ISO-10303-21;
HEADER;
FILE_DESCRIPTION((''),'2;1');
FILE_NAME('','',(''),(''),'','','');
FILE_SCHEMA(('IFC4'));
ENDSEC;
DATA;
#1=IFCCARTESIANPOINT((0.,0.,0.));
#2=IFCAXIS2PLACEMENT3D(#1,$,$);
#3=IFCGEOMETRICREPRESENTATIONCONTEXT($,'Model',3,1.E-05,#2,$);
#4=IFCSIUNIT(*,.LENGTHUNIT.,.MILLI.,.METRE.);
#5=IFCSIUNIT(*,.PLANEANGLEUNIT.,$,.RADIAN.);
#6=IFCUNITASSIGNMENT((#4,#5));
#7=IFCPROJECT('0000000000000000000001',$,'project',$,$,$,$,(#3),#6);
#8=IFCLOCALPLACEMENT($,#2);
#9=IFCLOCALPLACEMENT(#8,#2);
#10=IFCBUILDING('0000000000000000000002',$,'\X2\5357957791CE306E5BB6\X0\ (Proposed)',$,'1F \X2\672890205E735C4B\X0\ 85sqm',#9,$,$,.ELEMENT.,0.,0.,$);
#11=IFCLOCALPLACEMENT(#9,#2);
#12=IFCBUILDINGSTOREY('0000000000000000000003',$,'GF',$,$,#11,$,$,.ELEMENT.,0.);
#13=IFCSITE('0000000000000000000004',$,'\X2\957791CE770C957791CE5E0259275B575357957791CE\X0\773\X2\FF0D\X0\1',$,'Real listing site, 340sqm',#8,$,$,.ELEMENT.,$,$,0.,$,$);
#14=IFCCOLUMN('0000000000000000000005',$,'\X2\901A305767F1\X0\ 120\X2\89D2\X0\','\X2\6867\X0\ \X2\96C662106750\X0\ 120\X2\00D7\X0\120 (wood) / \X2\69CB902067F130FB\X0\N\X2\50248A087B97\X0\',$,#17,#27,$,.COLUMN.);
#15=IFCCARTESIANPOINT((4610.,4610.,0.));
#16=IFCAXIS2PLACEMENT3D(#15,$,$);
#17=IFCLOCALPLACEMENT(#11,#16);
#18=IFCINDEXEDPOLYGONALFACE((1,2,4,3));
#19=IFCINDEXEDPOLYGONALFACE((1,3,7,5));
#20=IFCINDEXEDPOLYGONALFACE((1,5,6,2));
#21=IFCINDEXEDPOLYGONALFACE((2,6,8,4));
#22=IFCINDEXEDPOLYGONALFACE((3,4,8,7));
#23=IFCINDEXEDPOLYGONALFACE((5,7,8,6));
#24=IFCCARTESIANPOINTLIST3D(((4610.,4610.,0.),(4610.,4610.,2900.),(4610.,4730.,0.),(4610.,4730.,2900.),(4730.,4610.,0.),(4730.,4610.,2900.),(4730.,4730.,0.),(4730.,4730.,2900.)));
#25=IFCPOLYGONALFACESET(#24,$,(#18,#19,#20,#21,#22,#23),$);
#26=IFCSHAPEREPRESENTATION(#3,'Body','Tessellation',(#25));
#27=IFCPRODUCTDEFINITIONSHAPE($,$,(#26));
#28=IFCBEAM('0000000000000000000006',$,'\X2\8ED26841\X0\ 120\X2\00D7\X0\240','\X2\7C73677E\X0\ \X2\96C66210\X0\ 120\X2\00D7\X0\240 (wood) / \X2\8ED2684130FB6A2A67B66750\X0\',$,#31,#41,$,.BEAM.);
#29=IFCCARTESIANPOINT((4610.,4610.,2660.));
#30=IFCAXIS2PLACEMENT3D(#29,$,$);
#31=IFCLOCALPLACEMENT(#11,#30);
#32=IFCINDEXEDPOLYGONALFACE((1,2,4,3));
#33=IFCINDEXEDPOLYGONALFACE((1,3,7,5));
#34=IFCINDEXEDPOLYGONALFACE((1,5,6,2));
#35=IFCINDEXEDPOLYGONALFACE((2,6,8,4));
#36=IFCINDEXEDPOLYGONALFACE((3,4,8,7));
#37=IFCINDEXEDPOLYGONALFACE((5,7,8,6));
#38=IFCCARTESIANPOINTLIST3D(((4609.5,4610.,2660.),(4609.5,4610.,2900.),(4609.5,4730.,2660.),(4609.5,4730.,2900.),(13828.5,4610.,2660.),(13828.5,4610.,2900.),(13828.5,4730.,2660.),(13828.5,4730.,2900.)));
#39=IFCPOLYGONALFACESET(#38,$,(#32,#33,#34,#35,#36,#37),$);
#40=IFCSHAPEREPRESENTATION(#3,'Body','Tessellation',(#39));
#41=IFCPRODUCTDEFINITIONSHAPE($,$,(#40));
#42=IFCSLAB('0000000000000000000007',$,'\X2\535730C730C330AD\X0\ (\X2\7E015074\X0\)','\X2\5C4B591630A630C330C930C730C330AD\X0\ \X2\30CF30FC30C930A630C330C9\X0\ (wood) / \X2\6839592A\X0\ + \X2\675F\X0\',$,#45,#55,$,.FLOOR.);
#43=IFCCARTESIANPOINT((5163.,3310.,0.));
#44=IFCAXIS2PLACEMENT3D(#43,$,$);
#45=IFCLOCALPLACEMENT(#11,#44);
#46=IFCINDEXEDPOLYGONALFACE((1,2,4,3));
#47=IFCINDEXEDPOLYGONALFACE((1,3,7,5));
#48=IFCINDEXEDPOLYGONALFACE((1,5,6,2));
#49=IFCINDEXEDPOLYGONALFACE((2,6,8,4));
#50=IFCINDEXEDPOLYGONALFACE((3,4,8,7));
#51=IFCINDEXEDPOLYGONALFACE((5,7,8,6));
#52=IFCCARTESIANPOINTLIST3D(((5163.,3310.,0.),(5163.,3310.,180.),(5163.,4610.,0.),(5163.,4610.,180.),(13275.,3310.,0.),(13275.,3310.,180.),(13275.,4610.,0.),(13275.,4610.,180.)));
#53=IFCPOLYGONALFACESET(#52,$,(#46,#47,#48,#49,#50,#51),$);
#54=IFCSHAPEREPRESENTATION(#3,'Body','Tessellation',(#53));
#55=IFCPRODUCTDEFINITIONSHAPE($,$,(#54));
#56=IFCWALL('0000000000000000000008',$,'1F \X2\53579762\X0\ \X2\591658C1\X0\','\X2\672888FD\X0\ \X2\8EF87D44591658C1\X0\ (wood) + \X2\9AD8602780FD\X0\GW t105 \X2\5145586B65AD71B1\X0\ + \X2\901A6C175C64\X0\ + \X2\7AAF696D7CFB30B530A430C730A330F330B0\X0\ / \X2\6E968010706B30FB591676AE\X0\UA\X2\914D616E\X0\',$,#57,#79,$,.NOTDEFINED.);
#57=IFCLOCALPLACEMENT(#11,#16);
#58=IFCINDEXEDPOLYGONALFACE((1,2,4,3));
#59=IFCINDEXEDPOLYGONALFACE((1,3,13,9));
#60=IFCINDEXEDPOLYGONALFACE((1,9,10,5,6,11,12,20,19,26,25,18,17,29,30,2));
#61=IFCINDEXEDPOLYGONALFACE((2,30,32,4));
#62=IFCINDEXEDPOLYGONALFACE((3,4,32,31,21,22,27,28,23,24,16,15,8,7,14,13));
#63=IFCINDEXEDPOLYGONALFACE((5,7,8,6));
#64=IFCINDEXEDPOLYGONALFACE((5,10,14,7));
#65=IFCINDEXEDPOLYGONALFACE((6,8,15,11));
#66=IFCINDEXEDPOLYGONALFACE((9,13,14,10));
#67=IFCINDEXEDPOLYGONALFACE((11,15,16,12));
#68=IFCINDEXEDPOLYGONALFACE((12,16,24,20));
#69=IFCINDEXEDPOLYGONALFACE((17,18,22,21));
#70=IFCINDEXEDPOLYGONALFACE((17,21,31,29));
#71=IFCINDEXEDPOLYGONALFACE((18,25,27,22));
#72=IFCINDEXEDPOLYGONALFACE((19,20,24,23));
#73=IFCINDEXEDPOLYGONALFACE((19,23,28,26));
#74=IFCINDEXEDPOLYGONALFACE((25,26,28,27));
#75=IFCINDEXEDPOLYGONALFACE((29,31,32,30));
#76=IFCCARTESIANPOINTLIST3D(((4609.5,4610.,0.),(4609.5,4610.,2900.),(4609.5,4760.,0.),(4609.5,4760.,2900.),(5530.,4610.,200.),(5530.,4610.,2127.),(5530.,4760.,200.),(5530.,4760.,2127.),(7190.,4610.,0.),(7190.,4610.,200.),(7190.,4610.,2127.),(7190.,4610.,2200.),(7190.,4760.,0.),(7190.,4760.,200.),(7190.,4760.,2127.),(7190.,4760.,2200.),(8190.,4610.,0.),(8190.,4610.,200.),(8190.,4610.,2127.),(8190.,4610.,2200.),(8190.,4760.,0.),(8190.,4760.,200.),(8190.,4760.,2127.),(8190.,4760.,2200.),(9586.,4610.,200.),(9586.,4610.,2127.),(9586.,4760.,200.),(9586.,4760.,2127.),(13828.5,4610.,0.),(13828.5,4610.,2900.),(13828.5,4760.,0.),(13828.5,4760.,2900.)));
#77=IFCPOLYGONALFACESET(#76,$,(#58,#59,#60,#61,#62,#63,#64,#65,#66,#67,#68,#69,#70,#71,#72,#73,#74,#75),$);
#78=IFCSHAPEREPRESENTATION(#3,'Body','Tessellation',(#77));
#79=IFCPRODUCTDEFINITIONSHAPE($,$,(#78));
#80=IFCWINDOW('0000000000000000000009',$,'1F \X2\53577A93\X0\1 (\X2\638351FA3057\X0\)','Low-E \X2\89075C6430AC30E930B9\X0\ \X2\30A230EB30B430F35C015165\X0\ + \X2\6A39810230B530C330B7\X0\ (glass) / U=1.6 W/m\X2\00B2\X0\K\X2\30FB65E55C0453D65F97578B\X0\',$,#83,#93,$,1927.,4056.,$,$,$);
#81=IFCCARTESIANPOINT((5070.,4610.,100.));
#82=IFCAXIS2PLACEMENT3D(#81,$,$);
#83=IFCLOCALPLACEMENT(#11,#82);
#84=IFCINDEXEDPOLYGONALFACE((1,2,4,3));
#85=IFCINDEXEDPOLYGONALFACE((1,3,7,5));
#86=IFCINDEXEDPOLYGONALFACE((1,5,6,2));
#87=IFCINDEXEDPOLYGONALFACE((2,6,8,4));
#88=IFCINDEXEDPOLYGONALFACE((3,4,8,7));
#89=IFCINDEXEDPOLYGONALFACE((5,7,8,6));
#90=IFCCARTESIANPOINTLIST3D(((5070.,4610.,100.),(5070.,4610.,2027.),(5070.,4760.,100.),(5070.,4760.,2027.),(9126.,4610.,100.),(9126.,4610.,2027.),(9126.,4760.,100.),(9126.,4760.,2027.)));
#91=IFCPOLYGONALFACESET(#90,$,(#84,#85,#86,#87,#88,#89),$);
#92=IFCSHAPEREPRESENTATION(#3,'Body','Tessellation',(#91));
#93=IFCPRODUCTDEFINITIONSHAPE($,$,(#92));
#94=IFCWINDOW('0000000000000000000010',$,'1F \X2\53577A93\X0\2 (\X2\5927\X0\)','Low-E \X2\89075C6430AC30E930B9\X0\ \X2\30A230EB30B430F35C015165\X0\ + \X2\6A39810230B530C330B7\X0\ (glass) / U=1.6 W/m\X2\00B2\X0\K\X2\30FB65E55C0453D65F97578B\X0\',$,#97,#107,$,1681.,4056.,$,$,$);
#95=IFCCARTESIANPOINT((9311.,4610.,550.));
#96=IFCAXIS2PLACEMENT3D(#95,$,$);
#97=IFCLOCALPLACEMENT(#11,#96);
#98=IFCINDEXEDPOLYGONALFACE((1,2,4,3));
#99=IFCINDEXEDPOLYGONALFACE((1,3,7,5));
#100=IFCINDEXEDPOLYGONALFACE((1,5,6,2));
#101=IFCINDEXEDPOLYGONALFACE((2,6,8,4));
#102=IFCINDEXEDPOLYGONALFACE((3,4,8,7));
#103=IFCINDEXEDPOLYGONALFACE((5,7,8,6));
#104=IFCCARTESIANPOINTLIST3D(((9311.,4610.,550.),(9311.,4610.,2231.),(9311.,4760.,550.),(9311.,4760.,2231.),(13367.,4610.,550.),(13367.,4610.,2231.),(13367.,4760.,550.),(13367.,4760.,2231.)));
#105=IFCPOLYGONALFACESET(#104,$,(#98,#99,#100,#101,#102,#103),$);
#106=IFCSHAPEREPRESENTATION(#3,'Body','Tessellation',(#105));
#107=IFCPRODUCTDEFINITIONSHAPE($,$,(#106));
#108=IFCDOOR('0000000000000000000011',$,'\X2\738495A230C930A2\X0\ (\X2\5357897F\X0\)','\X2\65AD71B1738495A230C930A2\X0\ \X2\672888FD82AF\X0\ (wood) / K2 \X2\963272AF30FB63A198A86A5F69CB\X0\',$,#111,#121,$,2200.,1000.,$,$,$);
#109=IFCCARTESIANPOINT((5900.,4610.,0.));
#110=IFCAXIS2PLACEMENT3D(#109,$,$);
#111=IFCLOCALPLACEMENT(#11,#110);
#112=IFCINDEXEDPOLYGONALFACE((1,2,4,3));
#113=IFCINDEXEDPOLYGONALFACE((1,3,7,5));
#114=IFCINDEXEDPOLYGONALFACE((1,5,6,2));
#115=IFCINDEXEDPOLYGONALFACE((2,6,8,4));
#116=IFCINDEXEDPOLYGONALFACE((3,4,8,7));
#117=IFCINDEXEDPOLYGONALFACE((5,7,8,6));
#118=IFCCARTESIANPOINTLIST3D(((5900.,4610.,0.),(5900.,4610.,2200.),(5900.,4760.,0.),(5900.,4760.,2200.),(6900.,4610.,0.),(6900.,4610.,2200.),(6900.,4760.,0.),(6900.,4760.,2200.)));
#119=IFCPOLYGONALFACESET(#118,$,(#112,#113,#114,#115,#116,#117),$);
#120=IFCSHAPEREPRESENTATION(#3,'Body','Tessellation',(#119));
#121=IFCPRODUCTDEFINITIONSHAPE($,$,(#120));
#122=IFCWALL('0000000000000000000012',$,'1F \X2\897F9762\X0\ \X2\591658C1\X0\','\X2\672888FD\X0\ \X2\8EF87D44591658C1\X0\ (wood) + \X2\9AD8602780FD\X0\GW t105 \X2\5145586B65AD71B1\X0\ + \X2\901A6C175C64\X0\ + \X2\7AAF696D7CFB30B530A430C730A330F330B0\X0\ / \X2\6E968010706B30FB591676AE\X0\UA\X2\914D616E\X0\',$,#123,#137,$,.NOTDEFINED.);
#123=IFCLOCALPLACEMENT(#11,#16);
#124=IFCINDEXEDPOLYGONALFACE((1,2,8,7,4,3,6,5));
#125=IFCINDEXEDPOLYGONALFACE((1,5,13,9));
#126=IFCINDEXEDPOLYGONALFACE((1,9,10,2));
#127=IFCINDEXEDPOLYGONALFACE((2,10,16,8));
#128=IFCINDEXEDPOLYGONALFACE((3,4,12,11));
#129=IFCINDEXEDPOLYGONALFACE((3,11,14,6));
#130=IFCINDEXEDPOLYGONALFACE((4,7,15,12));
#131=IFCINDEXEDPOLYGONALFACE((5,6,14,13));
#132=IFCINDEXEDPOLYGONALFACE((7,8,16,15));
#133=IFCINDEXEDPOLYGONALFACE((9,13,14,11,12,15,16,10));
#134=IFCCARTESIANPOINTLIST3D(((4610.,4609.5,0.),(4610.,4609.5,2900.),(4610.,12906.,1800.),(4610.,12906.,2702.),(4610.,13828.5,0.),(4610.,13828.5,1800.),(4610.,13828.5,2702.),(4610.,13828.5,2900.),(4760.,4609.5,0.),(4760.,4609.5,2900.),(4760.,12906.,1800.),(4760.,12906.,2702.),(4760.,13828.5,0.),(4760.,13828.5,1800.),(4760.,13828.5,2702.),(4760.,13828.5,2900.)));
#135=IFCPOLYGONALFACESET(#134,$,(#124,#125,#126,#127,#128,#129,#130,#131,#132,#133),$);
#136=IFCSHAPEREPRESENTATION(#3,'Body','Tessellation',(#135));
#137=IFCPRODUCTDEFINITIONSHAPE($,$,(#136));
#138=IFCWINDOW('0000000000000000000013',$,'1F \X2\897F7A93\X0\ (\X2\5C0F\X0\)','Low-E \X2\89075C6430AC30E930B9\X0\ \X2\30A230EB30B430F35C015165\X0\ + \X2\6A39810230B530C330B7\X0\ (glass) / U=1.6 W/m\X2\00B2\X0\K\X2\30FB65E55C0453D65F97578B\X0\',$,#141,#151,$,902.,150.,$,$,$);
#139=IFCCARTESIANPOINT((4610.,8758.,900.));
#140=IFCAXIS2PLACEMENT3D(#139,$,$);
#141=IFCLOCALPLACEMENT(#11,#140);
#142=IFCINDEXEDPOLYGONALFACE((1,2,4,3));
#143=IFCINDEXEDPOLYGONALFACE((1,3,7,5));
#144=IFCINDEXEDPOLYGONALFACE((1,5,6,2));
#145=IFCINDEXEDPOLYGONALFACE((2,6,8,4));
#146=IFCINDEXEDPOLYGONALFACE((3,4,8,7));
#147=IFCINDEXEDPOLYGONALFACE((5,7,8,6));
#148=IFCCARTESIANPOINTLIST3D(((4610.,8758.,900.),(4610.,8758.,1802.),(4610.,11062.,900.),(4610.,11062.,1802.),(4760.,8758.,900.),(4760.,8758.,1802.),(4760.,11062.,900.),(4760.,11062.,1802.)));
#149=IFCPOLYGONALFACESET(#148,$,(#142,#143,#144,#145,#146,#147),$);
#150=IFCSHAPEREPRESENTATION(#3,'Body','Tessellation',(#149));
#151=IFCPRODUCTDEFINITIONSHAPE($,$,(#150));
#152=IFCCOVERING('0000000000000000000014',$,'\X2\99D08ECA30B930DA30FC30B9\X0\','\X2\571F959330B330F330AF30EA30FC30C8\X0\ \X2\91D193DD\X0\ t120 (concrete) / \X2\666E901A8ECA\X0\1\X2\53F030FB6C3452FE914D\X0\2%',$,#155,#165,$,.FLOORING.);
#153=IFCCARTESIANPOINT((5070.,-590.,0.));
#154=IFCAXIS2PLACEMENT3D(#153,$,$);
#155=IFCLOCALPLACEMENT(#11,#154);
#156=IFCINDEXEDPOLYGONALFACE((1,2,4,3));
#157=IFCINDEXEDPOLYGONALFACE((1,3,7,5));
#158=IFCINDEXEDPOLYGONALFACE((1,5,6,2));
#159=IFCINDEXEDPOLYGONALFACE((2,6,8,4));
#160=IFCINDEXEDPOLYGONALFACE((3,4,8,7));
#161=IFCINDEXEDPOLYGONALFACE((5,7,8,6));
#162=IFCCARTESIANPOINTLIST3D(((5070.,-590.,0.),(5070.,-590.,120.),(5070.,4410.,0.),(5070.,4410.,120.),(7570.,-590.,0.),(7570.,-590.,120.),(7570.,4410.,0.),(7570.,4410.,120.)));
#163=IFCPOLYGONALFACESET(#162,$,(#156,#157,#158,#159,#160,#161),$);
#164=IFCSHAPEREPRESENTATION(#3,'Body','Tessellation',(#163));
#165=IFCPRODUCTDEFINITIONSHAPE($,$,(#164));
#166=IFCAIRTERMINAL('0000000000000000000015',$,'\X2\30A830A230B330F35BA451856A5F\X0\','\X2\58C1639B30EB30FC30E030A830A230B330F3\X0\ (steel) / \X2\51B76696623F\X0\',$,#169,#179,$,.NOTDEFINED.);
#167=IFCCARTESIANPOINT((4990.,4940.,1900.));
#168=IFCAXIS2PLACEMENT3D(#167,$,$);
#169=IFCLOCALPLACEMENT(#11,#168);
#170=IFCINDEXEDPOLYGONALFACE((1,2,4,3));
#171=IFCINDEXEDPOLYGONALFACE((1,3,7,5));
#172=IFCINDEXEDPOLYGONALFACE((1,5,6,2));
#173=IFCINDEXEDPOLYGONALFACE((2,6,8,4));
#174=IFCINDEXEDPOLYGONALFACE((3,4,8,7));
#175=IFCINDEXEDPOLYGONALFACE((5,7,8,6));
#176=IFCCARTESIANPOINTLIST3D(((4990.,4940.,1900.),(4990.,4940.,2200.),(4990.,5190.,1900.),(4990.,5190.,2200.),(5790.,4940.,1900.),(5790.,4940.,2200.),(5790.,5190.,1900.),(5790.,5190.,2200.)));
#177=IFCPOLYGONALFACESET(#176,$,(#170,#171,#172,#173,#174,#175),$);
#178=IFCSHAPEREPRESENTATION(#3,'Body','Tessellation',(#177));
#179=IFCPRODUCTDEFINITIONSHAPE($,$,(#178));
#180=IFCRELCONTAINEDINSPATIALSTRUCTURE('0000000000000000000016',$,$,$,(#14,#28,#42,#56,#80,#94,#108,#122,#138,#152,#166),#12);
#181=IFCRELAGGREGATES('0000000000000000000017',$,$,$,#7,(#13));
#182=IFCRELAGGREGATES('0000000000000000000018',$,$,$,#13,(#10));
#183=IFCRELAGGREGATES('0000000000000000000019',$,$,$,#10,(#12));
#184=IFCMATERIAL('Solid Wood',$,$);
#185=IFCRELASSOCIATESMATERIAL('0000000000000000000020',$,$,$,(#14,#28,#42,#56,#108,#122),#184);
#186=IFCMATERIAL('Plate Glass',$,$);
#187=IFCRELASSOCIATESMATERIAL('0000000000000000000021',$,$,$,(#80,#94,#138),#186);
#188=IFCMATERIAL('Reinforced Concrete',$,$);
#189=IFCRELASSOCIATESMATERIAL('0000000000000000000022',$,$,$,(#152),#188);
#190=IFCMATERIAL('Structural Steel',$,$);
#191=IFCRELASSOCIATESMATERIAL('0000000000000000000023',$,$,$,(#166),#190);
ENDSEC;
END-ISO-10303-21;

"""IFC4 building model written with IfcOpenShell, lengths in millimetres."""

from ifc_helpers import new_model, si_unit, frame, frame_2d, origin, place, context, project, spatial, rectangle, extrude, material, element, fill, save


model = new_model("IFC4")

# Units and contexts
model_context = context("Model", 3, precision=1e-05, world=origin())
ifc_project = project(units=[si_unit("LENGTHUNIT", "METRE", prefix="MILLI"), si_unit("PLANEANGLEUNIT", "RADIAN")], contexts=[model_context])

# Site, building, storey
site_placement = place(None, origin())
site = spatial("IfcSite", under=ifc_project, at=site_placement, Name="長野県長野市大字南長野773－1", ObjectType="Real listing site, 340sqm", CompositionType="ELEMENT", RefElevation=0.0)
building_placement = place(site_placement, origin())
building = spatial("IfcBuilding", under=site, at=building_placement, Name="南長野の家 (Proposed)", ObjectType="1F 木造平屋 85sqm", CompositionType="ELEMENT", ElevationOfRefHeight=0.0, ElevationOfTerrain=0.0)
storey_placement = place(building_placement, origin())
storey = spatial("IfcBuildingStorey", under=building, at=storey_placement, Name="GF", CompositionType="ELEMENT", Elevation=0.0)

# Column
ifc_material_1 = material(Name="Solid Wood")
column_1_placement = place(storey_placement, frame((4610.0, 4610.0, 0.0)))
element("IfcColumn", 1, at=column_1_placement, inside=storey, material=ifc_material_1, Name="通し柱 120角", Description="桧 集成材 120×120 (wood) / 構造柱・N値計算", PredefinedType="COLUMN", context=model_context, shape_type="SweptSolid", body=[
    extrude(rectangle(XDim=120.0, YDim=120.0, at=frame_2d((60.0, 60.0))), frame((4610.0, 4610.0, 0.0)), (0.0, 0.0, 1.0), 2900.0),
])

# Beam
beam_1_placement = place(storey_placement, frame((4610.0, 4610.0, 2660.0)))
element("IfcBeam", 2, at=beam_1_placement, inside=storey, material=ifc_material_1, Name="軒桁 120×240", Description="米松 集成 120×240 (wood) / 軒桁・横架材", PredefinedType="BEAM", context=model_context, shape_type="SweptSolid", body=[
    extrude(rectangle(XDim=9219.0, YDim=120.0, at=frame_2d((4609.0, 60.0))), frame((4610.0, 4610.0, 2660.0)), (0.0, 0.0, 1.0), 240.0),
])

# Slab
ifc_material_2 = material(Name="Reinforced Concrete")
slab_1_placement = place(storey_placement, frame((5163.0, 3310.0, 0.0)))
element("IfcSlab", 3, at=slab_1_placement, inside=storey, material=ifc_material_1, Name="南デッキ (縁側)", Description="屋外ウッドデッキ ハードウッド (wood) / 根太 + 束", PredefinedType="FLOOR", context=model_context, shape_type="SweptSolid", body=[
    extrude(rectangle(XDim=8112.0, YDim=1300.0, at=frame_2d((4056.0, 650.0))), frame((5163.0, 3310.0, 0.0)), (0.0, 0.0, 1.0), 180.0),
])

# Wall, openings, windows, door
wall_1_placement = place(storey_placement, frame((4610.0, 4610.0, 0.0)))
wall_1 = element("IfcWall", 4, at=wall_1_placement, inside=storey, material=ifc_material_1, Name="1F 南面 外壁", Description="木製 軸組外壁 (wood) + 高性能GW t105 充填断熱 + 通気層 + 窯業系サイディング / 準耐火・外皮UA配慮", PredefinedType="NOTDEFINED", context=model_context, shape_type="SweptSolid", body=[
    extrude(rectangle(XDim=9219.0, YDim=150.0, at=frame_2d((4609.0, 75.0))), frame((4610.0, 4610.0, 0.0)), (0.0, 0.0, 1.0), 2900.0),
])
opening_1_placement = place(storey_placement, frame((5070.0, 4610.0, 100.0)))
opening_1 = element("IfcOpeningElement", 5, at=opening_1_placement, cuts=wall_1, PredefinedType="NOTDEFINED", context=model_context, shape_type="SweptSolid", body=[
    extrude(rectangle(XDim=4056.0, YDim=150.0, at=frame_2d((2028.0, 75.0))), frame((5070.0, 4610.0, 100.0)), (0.0, 0.0, 1.0), 1927.0),
])
opening_2_placement = place(storey_placement, frame((9311.0, 4610.0, 550.0)))
opening_2 = element("IfcOpeningElement", 6, at=opening_2_placement, cuts=wall_1, PredefinedType="NOTDEFINED", context=model_context, shape_type="SweptSolid", body=[
    extrude(rectangle(XDim=4056.0, YDim=150.0, at=frame_2d((2028.0, 75.0))), frame((9311.0, 4610.0, 550.0)), (0.0, 0.0, 1.0), 1681.0),
])
opening_3_placement = place(storey_placement, frame((5900.0, 4610.0, 0.0)))
opening_3 = element("IfcOpeningElement", 7, at=opening_3_placement, cuts=wall_1, PredefinedType="NOTDEFINED", context=model_context, shape_type="SweptSolid", body=[
    extrude(rectangle(XDim=1000.0, YDim=150.0, at=frame_2d((500.0, 75.0))), frame((5900.0, 4610.0, 0.0)), (0.0, 0.0, 1.0), 2200.0),
])
ifc_material_3 = material(Name="Plate Glass")
window_1_placement = place(storey_placement, frame((5070.0, 4610.0, 100.0)))
window_1 = element("IfcWindow", 8, at=window_1_placement, inside=storey, material=ifc_material_3, Name="1F 南窓1 (掃出し)", Description="Low-E 複層ガラス アルゴン封入 + 樹脂サッシ (glass) / U=1.6 W/m²K・日射取得型", OverallHeight=1927.0, OverallWidth=4056.0, context=model_context, shape_type="SweptSolid", body=[
    extrude(rectangle(XDim=4056.0, YDim=150.0, at=frame_2d((2028.0, 75.0))), frame((5070.0, 4610.0, 100.0)), (0.0, 0.0, 1.0), 1927.0),
])
fill(opening_1, window_1)
window_2_placement = place(storey_placement, frame((9311.0, 4610.0, 550.0)))
window_2 = element("IfcWindow", 9, at=window_2_placement, inside=storey, material=ifc_material_3, Name="1F 南窓2 (大)", Description="Low-E 複層ガラス アルゴン封入 + 樹脂サッシ (glass) / U=1.6 W/m²K・日射取得型", OverallHeight=1681.0, OverallWidth=4056.0, context=model_context, shape_type="SweptSolid", body=[
    extrude(rectangle(XDim=4056.0, YDim=150.0, at=frame_2d((2028.0, 75.0))), frame((9311.0, 4610.0, 550.0)), (0.0, 0.0, 1.0), 1681.0),
])
fill(opening_2, window_2)
door_placement = place(storey_placement, frame((5900.0, 4610.0, 0.0)))
door = element("IfcDoor", 10, at=door_placement, inside=storey, material=ifc_material_1, Name="玄関ドア (南西)", Description="断熱玄関ドア 木製芯 (wood) / K2 防犯・採風機構", OverallHeight=2200.0, OverallWidth=1000.0, context=model_context, shape_type="SweptSolid", body=[
    extrude(rectangle(XDim=1000.0, YDim=150.0, at=frame_2d((500.0, 75.0))), frame((5900.0, 4610.0, 0.0)), (0.0, 0.0, 1.0), 2200.0),
])
fill(opening_3, door)

# Wall, opening, window
wall_2_placement = place(storey_placement, frame((4610.0, 4610.0, 0.0)))
wall_2 = element("IfcWall", 11, at=wall_2_placement, inside=storey, material=ifc_material_1, Name="1F 西面 外壁", Description="木製 軸組外壁 (wood) + 高性能GW t105 充填断熱 + 通気層 + 窯業系サイディング / 準耐火・外皮UA配慮", PredefinedType="NOTDEFINED", context=model_context, shape_type="SweptSolid", body=[
    extrude(rectangle(XDim=150.0, YDim=9219.0, at=frame_2d((75.0, 4609.0))), frame((4610.0, 4610.0, 0.0)), (0.0, 0.0, 1.0), 2900.0),
])
opening_4_placement = place(storey_placement, frame((4610.0, 8758.0, 900.0)))
opening_4 = element("IfcOpeningElement", 12, at=opening_4_placement, cuts=wall_2, PredefinedType="NOTDEFINED", context=model_context, shape_type="SweptSolid", body=[
    extrude(rectangle(XDim=150.0, YDim=2304.0, at=frame_2d((75.0, 1152.0))), frame((4610.0, 8758.0, 900.0)), (0.0, 0.0, 1.0), 902.0),
])
window_3_placement = place(storey_placement, frame((4610.0, 8758.0, 900.0)))
window_3 = element("IfcWindow", 13, at=window_3_placement, inside=storey, material=ifc_material_3, Name="1F 西窓 (小)", Description="Low-E 複層ガラス アルゴン封入 + 樹脂サッシ (glass) / U=1.6 W/m²K・日射取得型", OverallHeight=902.0, OverallWidth=150.0, context=model_context, shape_type="SweptSolid", body=[
    extrude(rectangle(XDim=150.0, YDim=2304.0, at=frame_2d((75.0, 1152.0))), frame((4610.0, 8758.0, 900.0)), (0.0, 0.0, 1.0), 902.0),
])
fill(opening_4, window_3)

# Shared definitions
ifc_material_4 = material(Name="Structural Steel")

# Covering
covering_1_placement = place(storey_placement, frame((5070.0, -590.0, 0.0)))
element("IfcCovering", 14, at=covering_1_placement, inside=storey, material=ifc_material_2, Name="駐車スペース", Description="土間コンクリート 金鏝 t120 (concrete) / 普通車1台・水勾配2%", PredefinedType="FLOORING", context=model_context, shape_type="SweptSolid", body=[
    extrude(rectangle(XDim=2500.0, YDim=5000.0, at=frame_2d((1250.0, 2500.0))), frame((5070.0, -590.0, 0.0)), (0.0, 0.0, 1.0), 120.0),
])

# Air terminal
air_terminal_placement = place(storey_placement, frame((4990.0, 4940.0, 1900.0)))
element("IfcAirTerminal", 15, at=air_terminal_placement, inside=storey, material=ifc_material_4, Name="エアコン室内機", Description="壁掛ルームエアコン (steel) / 冷暖房", PredefinedType="NOTDEFINED", context=model_context, shape_type="SweptSolid", body=[
    extrude(rectangle(XDim=800.0, YDim=250.0, at=frame_2d((400.0, 125.0))), frame((4990.0, 4940.0, 1900.0)), (0.0, 0.0, 1.0), 300.0),
])

save(model, "model.ifc")
